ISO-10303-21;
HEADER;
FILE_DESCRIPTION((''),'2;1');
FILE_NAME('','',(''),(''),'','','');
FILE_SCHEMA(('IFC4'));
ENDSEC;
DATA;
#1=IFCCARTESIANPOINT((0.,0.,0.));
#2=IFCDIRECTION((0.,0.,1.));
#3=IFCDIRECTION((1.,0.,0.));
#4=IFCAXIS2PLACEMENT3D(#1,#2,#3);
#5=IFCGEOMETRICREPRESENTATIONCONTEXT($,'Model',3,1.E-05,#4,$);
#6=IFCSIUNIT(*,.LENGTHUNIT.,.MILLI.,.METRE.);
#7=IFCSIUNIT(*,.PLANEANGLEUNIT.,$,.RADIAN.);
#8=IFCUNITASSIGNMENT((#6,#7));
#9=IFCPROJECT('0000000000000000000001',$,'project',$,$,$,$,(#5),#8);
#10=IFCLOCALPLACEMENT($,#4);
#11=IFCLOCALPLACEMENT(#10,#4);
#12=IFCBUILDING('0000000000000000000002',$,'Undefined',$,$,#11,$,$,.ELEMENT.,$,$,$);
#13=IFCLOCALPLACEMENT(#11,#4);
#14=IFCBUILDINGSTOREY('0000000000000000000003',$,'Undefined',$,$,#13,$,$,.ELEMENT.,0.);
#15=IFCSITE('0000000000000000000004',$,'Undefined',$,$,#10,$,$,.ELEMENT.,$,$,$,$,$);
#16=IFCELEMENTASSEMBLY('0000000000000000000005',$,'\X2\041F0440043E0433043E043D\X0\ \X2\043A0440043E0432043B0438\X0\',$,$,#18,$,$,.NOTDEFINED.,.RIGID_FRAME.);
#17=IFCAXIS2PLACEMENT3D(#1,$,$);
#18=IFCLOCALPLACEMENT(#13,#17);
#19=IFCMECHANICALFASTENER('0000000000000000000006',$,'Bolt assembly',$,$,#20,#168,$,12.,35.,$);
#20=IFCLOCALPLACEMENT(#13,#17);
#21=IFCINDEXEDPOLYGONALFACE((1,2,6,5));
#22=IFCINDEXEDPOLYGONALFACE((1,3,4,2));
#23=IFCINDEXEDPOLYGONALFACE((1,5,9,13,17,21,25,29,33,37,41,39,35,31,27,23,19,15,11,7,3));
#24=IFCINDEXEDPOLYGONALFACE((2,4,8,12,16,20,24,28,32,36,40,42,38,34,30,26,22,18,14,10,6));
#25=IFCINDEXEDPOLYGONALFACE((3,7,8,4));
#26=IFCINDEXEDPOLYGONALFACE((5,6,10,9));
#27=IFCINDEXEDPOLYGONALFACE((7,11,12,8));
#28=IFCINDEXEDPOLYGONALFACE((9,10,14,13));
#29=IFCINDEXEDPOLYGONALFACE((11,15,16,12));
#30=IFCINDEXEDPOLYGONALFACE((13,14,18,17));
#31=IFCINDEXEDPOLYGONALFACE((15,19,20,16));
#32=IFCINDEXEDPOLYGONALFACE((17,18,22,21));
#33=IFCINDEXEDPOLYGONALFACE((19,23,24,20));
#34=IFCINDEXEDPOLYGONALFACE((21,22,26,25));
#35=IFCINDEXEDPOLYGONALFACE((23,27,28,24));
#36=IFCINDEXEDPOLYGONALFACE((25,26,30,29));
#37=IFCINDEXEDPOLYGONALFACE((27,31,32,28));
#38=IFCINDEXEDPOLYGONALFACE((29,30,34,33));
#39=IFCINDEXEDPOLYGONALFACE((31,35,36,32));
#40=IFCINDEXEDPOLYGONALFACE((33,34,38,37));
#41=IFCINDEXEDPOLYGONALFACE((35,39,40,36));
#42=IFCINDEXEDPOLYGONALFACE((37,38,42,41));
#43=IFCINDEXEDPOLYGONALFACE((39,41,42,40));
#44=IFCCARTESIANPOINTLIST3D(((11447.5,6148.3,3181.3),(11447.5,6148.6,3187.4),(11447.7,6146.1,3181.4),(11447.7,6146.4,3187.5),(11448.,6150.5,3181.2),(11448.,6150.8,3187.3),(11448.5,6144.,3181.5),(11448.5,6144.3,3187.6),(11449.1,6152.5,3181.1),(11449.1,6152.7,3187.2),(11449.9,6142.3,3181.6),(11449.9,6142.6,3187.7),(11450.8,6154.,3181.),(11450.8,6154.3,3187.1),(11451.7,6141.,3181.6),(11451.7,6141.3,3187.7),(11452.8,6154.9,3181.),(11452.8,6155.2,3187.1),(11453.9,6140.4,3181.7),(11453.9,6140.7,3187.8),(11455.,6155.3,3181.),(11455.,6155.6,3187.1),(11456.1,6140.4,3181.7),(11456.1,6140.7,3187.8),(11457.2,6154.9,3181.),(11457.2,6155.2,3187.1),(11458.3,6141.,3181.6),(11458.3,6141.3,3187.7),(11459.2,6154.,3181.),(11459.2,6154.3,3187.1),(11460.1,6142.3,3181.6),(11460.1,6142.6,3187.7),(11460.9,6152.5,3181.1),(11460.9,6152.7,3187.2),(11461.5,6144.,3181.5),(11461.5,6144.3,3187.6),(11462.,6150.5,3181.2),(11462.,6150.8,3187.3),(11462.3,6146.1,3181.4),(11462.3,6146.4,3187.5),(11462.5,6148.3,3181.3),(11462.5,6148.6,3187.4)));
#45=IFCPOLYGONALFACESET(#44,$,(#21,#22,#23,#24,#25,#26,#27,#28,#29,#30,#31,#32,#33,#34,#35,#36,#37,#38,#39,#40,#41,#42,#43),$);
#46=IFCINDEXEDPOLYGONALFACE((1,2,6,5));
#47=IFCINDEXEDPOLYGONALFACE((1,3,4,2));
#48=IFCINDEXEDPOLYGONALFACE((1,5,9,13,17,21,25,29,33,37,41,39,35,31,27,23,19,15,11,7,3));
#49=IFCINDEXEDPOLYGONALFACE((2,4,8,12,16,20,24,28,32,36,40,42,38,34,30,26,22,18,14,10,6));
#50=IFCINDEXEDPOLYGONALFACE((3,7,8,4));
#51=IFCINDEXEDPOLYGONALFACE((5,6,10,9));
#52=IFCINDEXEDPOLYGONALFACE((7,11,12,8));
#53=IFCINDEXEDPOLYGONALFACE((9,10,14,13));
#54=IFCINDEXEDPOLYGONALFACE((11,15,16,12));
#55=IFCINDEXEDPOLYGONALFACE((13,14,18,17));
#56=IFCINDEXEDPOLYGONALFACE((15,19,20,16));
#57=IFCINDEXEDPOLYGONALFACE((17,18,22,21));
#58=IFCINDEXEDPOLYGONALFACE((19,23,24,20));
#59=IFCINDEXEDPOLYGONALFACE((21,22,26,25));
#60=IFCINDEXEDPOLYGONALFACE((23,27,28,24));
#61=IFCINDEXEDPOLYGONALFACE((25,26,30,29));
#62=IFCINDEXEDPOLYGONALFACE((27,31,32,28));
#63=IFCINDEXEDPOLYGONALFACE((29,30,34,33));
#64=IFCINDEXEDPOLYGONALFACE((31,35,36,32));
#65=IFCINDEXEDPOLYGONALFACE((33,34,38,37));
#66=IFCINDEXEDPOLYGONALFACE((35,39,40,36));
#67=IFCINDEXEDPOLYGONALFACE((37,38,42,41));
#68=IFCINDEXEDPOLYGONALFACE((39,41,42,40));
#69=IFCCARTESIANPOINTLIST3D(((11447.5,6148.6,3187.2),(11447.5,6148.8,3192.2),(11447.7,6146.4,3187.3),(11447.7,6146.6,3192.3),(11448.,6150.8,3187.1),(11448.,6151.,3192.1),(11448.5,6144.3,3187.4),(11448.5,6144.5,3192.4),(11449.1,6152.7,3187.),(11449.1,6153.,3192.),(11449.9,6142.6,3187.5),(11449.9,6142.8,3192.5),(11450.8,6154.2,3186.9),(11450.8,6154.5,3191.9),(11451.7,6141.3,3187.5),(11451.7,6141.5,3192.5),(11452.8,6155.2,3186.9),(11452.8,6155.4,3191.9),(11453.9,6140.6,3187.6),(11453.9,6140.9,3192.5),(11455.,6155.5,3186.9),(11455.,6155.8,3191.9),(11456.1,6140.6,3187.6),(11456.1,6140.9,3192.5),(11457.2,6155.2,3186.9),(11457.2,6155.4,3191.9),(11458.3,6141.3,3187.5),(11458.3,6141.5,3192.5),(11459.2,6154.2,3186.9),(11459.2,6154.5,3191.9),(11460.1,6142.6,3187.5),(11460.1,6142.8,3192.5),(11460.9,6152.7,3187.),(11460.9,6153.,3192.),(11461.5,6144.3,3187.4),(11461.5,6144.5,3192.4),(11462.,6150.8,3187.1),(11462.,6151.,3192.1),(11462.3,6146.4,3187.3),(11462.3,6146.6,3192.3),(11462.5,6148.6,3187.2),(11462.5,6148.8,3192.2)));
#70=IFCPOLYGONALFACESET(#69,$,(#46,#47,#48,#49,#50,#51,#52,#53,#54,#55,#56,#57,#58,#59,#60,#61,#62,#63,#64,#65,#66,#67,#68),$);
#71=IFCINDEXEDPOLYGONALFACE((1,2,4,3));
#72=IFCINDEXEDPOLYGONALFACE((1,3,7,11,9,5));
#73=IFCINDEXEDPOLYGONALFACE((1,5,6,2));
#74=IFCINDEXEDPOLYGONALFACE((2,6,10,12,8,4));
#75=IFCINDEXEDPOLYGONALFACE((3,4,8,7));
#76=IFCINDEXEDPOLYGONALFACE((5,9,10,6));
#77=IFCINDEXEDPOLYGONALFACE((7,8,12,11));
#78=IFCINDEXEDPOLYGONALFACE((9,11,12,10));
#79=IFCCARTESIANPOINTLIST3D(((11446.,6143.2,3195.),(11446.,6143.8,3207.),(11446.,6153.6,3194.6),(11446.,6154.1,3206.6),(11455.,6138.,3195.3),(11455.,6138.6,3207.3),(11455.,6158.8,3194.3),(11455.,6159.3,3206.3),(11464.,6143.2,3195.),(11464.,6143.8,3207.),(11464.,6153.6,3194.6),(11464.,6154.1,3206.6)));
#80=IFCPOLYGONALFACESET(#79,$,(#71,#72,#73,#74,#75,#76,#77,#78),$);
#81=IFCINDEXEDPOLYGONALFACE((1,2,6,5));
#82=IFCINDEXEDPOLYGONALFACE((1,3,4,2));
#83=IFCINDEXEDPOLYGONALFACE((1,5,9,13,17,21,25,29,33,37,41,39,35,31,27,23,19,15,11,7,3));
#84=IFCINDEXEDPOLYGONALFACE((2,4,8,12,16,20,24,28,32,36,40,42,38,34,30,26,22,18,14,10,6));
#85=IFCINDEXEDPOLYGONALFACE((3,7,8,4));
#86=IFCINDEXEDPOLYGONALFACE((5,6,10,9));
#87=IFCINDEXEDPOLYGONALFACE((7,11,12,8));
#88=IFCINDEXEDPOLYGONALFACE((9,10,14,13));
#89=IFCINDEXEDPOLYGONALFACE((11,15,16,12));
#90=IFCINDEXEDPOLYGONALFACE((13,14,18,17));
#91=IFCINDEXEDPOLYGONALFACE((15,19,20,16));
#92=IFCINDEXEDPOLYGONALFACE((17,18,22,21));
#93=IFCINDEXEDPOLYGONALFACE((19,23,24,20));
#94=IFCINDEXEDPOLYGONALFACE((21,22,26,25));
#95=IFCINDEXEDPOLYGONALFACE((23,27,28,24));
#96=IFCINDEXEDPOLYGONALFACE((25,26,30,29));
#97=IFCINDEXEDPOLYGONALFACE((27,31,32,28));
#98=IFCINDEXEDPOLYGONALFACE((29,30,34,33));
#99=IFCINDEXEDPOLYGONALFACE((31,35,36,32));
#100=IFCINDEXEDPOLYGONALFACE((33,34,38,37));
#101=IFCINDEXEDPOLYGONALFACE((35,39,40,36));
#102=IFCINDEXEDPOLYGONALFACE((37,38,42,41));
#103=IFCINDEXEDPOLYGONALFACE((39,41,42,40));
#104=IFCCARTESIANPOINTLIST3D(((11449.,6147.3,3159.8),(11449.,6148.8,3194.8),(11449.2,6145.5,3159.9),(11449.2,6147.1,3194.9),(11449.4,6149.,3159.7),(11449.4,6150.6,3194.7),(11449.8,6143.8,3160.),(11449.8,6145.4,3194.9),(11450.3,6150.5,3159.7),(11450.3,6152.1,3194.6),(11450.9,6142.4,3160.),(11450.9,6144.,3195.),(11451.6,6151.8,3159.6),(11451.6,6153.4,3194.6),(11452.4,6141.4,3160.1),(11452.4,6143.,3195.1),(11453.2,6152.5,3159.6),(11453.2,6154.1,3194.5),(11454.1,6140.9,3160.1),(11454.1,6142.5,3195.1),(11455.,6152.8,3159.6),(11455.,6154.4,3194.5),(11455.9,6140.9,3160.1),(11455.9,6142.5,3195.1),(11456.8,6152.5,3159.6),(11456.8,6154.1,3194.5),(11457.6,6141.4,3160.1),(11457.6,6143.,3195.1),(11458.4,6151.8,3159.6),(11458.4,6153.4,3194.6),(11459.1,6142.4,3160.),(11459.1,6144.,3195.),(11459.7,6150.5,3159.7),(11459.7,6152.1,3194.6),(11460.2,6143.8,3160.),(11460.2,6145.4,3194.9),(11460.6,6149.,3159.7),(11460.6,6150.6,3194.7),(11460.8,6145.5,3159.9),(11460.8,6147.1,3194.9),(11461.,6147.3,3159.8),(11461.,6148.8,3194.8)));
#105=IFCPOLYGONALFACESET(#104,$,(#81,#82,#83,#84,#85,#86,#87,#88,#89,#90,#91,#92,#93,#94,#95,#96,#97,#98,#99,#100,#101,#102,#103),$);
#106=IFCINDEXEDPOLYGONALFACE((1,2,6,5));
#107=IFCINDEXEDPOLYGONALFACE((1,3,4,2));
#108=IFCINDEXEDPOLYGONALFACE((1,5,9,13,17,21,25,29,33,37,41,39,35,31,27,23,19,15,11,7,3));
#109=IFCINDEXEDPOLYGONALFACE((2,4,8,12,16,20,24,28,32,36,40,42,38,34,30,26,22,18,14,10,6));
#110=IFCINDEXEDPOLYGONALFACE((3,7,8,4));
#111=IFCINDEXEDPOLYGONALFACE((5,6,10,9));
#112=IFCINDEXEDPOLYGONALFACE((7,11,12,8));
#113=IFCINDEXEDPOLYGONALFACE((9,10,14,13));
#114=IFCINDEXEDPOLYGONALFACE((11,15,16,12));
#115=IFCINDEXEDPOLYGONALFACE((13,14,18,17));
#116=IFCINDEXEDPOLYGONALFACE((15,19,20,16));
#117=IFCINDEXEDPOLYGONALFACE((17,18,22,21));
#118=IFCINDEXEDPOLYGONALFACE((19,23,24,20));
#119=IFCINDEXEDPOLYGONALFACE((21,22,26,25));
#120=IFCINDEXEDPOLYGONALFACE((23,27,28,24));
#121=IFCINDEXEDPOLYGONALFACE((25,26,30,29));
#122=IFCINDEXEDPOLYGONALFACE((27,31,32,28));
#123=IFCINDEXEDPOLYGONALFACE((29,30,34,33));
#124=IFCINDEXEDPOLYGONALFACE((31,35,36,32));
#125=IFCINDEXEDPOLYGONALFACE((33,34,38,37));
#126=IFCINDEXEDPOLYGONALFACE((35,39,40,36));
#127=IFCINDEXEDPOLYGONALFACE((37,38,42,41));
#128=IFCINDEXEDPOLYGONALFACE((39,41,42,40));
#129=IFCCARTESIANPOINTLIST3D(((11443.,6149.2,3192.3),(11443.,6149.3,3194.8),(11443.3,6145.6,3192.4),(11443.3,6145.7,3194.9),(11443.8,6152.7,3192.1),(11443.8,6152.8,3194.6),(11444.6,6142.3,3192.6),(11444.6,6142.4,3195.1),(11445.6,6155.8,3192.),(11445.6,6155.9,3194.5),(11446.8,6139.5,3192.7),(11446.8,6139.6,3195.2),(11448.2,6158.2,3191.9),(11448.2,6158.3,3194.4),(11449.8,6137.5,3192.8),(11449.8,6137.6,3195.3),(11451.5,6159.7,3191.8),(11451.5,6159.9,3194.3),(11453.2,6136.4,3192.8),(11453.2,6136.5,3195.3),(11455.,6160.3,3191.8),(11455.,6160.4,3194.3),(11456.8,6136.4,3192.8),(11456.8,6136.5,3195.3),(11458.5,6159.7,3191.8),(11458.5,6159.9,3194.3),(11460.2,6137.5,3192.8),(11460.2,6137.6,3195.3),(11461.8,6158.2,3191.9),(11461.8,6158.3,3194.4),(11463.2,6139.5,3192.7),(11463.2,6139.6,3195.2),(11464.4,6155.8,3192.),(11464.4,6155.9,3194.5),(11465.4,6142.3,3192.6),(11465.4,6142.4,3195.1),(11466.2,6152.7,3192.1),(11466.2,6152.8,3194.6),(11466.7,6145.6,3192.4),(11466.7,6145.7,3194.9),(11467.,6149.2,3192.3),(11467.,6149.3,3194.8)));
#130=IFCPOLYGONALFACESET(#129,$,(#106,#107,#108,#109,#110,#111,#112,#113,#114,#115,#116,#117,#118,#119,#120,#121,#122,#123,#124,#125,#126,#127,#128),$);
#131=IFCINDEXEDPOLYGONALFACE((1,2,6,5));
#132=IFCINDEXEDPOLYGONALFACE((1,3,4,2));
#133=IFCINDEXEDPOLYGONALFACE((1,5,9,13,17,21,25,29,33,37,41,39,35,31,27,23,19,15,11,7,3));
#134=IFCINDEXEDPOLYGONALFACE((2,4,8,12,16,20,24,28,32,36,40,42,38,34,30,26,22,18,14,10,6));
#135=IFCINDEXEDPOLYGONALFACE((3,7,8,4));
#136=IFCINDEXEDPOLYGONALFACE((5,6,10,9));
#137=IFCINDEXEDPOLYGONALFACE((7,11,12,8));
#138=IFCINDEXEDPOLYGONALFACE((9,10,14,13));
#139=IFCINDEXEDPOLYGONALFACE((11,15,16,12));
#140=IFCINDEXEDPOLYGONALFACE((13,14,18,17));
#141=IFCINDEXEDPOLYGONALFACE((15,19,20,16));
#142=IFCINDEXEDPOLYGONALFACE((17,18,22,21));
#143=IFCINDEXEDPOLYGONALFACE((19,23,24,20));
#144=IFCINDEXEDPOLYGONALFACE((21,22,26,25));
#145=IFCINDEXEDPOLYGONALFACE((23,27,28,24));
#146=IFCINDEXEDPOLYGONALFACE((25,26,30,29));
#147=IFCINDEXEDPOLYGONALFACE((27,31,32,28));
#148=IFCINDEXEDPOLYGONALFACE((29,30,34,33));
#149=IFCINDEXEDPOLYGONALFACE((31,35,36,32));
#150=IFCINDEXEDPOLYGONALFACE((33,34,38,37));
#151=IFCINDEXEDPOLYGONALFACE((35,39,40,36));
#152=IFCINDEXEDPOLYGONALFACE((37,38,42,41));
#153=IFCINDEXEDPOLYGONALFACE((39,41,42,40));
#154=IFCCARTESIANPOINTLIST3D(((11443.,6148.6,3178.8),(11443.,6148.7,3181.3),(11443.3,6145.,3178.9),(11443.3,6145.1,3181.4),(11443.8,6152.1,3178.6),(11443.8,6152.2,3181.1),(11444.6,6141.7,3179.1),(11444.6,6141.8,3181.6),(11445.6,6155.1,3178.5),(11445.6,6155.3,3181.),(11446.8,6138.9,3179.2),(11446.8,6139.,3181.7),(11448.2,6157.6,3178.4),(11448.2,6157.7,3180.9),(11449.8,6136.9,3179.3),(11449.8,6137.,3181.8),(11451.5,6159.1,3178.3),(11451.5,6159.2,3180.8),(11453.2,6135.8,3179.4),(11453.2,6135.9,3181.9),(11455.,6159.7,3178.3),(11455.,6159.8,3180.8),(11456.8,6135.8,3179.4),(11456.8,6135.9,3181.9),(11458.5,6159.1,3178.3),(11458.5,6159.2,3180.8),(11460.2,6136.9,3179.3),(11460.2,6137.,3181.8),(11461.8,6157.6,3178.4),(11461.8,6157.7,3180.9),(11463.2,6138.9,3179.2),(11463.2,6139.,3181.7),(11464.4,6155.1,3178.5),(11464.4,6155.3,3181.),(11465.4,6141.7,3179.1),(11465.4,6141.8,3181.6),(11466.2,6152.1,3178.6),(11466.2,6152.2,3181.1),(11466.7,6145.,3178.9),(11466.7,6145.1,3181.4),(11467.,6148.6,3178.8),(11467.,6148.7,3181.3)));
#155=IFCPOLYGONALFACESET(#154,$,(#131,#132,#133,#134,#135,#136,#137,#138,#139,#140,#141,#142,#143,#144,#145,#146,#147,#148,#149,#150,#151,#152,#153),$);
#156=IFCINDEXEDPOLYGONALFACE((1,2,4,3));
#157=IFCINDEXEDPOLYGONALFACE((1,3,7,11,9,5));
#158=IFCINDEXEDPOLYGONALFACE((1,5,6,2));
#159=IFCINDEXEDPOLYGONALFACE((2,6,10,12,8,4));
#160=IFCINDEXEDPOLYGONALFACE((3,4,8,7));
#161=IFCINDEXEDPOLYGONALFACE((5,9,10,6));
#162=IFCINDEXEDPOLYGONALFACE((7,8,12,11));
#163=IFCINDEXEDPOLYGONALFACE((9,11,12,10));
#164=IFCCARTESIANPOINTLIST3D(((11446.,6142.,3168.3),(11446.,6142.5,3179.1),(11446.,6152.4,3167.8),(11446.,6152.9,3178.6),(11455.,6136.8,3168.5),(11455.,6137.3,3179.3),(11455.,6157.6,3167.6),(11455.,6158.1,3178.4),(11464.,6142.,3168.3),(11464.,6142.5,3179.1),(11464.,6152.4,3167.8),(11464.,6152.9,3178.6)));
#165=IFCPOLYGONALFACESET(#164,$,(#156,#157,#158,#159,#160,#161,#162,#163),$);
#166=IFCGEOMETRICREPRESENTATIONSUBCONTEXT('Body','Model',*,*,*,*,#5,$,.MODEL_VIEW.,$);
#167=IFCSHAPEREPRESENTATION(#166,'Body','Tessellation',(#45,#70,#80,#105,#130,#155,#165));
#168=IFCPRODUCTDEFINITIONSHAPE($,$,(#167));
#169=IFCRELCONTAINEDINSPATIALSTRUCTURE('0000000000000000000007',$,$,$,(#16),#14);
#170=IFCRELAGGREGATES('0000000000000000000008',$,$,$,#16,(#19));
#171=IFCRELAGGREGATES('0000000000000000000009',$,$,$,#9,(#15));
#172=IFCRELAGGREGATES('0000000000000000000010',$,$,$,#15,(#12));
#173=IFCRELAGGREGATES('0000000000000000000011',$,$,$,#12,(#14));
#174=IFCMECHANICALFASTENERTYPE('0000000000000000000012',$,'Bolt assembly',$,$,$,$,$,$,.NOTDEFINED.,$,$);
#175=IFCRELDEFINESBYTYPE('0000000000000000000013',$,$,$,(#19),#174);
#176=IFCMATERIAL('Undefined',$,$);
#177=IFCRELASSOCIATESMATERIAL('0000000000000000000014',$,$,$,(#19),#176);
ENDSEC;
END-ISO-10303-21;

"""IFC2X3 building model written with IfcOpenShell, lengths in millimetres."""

from ifc_helpers import new_model, si_unit, frame, origin_with_axes, origin_2d_with_axis, place, context, subcontext, project, spatial, polyline, circle, outline, extrude, source, transform, mapped, material, type_object, element, aggregate, save


model = new_model("IFC2X3")

# Units and contexts
model_context = context("Model", 3, precision=1e-05, world=origin_with_axes())
body_context = subcontext(model_context, "Body", "Model", "MODEL_VIEW")
ifc_project = project(units=[si_unit("LENGTHUNIT", "METRE", prefix="MILLI"), si_unit("PLANEANGLEUNIT", "RADIAN")], contexts=[model_context])

# Site, building, storey
site_placement = place(None, origin_with_axes())
site = spatial("IfcSite", under=ifc_project, at=site_placement, Name="Undefined", CompositionType="ELEMENT")
building_placement = place(site_placement, origin_with_axes())
building = spatial("IfcBuilding", under=site, at=building_placement, Name="Undefined", CompositionType="ELEMENT")
storey_placement = place(building_placement, origin_with_axes())
storey = spatial("IfcBuildingStorey", under=building, at=storey_placement, Name="Undefined", CompositionType="ELEMENT", Elevation=0.0)

# Element assembly
assembly_1_placement = place(storey_placement, origin_with_axes())
assembly_1 = element("IfcElementAssembly", 1, at=assembly_1_placement, inside=storey, Name="Прогон кровли", AssemblyPlace="NOTDEFINED", PredefinedType="RIGID_FRAME")

# Mechanical fastener
ifc_material_1 = material(Name="Undefined")
mechanical_fastener_type = type_object("IfcMechanicalFastenerType", Name="Bolt assembly")
shared_shape_1 = source(origin_with_axes(), body_context, "Body", "SweptSolid", [
    extrude(circle(Radius=7.5, at=origin_2d_with_axis()), frame((0.0, -0.1, 0.0), z_axis=(0.0, 1.0, 0.0), x_axis=(1.0, 0.0, 0.0)), (0.0, 0.0, 1.0), 6.1),
    extrude(circle(Radius=7.5, at=origin_2d_with_axis()), frame((0.0, -4.9, 0.0), z_axis=(0.0, 1.0, 0.0), x_axis=(1.0, 0.0, 0.0)), (0.0, 0.0, 1.0), 5.0),
    extrude(outline(polyline([(10.4, 0.0), (5.2, 9.0), (-5.2, 9.0), (-10.4, 0.0), (-5.2, -9.0), (5.2, -9.0), (10.4, 0.0)])), frame((0.0, -19.5, 0.0), z_axis=(0.0, 1.0, 0.0), x_axis=(1.0, 0.0, 0.0)), (0.0, 0.0, 1.0), 12.0),
    extrude(circle(Radius=6.0, at=origin_2d_with_axis()), frame((0.0, -7.5, 0.0), z_axis=(0.0, 1.0, 0.0), x_axis=(1.0, 0.0, 0.0)), (0.0, 0.0, 1.0), 35.0),
    extrude(circle(Radius=12.0, at=origin_2d_with_axis()), frame((0.0, -7.5, 0.0), z_axis=(0.0, 1.0, 0.0), x_axis=(1.0, 0.0, 0.0)), (0.0, 0.0, 1.0), 2.5),
    extrude(circle(Radius=12.0, at=origin_2d_with_axis()), frame((0.0, 6.0, 0.0), z_axis=(0.0, 1.0, 0.0), x_axis=(1.0, 0.0, 0.0)), (0.0, 0.0, 1.0), 2.5),
    extrude(outline(polyline([(10.4, 0.0), (5.2, 9.0), (-5.2, 9.0), (-10.4, 0.0), (-5.2, -9.0), (5.2, -9.0), (10.4, 0.0)])), frame((0.0, 8.5, 0.0), z_axis=(0.0, 1.0, 0.0), x_axis=(1.0, 0.0, 0.0)), (0.0, 0.0, 1.0), 10.8),
])
mechanical_fastener_1_placement = place(assembly_1_placement, frame((11455.0, 6148.1, 3187.3), z_axis=(-1.0, 0.0, 0.0), x_axis=(0.0, 0.998969, -0.045408)))
mechanical_fastener_1 = element("IfcMechanicalFastener", 2, at=mechanical_fastener_1_placement, type_object=mechanical_fastener_type, material=ifc_material_1, Name="Bolt assembly", NominalDiameter=12.0, NominalLength=35.0, context=body_context, shape_type="MappedRepresentation", body=[
    mapped(shared_shape_1, transform((0.0, 0.0, 0.0))),
])
aggregate(assembly_1, [mechanical_fastener_1])

save(model, "model.ifc")
